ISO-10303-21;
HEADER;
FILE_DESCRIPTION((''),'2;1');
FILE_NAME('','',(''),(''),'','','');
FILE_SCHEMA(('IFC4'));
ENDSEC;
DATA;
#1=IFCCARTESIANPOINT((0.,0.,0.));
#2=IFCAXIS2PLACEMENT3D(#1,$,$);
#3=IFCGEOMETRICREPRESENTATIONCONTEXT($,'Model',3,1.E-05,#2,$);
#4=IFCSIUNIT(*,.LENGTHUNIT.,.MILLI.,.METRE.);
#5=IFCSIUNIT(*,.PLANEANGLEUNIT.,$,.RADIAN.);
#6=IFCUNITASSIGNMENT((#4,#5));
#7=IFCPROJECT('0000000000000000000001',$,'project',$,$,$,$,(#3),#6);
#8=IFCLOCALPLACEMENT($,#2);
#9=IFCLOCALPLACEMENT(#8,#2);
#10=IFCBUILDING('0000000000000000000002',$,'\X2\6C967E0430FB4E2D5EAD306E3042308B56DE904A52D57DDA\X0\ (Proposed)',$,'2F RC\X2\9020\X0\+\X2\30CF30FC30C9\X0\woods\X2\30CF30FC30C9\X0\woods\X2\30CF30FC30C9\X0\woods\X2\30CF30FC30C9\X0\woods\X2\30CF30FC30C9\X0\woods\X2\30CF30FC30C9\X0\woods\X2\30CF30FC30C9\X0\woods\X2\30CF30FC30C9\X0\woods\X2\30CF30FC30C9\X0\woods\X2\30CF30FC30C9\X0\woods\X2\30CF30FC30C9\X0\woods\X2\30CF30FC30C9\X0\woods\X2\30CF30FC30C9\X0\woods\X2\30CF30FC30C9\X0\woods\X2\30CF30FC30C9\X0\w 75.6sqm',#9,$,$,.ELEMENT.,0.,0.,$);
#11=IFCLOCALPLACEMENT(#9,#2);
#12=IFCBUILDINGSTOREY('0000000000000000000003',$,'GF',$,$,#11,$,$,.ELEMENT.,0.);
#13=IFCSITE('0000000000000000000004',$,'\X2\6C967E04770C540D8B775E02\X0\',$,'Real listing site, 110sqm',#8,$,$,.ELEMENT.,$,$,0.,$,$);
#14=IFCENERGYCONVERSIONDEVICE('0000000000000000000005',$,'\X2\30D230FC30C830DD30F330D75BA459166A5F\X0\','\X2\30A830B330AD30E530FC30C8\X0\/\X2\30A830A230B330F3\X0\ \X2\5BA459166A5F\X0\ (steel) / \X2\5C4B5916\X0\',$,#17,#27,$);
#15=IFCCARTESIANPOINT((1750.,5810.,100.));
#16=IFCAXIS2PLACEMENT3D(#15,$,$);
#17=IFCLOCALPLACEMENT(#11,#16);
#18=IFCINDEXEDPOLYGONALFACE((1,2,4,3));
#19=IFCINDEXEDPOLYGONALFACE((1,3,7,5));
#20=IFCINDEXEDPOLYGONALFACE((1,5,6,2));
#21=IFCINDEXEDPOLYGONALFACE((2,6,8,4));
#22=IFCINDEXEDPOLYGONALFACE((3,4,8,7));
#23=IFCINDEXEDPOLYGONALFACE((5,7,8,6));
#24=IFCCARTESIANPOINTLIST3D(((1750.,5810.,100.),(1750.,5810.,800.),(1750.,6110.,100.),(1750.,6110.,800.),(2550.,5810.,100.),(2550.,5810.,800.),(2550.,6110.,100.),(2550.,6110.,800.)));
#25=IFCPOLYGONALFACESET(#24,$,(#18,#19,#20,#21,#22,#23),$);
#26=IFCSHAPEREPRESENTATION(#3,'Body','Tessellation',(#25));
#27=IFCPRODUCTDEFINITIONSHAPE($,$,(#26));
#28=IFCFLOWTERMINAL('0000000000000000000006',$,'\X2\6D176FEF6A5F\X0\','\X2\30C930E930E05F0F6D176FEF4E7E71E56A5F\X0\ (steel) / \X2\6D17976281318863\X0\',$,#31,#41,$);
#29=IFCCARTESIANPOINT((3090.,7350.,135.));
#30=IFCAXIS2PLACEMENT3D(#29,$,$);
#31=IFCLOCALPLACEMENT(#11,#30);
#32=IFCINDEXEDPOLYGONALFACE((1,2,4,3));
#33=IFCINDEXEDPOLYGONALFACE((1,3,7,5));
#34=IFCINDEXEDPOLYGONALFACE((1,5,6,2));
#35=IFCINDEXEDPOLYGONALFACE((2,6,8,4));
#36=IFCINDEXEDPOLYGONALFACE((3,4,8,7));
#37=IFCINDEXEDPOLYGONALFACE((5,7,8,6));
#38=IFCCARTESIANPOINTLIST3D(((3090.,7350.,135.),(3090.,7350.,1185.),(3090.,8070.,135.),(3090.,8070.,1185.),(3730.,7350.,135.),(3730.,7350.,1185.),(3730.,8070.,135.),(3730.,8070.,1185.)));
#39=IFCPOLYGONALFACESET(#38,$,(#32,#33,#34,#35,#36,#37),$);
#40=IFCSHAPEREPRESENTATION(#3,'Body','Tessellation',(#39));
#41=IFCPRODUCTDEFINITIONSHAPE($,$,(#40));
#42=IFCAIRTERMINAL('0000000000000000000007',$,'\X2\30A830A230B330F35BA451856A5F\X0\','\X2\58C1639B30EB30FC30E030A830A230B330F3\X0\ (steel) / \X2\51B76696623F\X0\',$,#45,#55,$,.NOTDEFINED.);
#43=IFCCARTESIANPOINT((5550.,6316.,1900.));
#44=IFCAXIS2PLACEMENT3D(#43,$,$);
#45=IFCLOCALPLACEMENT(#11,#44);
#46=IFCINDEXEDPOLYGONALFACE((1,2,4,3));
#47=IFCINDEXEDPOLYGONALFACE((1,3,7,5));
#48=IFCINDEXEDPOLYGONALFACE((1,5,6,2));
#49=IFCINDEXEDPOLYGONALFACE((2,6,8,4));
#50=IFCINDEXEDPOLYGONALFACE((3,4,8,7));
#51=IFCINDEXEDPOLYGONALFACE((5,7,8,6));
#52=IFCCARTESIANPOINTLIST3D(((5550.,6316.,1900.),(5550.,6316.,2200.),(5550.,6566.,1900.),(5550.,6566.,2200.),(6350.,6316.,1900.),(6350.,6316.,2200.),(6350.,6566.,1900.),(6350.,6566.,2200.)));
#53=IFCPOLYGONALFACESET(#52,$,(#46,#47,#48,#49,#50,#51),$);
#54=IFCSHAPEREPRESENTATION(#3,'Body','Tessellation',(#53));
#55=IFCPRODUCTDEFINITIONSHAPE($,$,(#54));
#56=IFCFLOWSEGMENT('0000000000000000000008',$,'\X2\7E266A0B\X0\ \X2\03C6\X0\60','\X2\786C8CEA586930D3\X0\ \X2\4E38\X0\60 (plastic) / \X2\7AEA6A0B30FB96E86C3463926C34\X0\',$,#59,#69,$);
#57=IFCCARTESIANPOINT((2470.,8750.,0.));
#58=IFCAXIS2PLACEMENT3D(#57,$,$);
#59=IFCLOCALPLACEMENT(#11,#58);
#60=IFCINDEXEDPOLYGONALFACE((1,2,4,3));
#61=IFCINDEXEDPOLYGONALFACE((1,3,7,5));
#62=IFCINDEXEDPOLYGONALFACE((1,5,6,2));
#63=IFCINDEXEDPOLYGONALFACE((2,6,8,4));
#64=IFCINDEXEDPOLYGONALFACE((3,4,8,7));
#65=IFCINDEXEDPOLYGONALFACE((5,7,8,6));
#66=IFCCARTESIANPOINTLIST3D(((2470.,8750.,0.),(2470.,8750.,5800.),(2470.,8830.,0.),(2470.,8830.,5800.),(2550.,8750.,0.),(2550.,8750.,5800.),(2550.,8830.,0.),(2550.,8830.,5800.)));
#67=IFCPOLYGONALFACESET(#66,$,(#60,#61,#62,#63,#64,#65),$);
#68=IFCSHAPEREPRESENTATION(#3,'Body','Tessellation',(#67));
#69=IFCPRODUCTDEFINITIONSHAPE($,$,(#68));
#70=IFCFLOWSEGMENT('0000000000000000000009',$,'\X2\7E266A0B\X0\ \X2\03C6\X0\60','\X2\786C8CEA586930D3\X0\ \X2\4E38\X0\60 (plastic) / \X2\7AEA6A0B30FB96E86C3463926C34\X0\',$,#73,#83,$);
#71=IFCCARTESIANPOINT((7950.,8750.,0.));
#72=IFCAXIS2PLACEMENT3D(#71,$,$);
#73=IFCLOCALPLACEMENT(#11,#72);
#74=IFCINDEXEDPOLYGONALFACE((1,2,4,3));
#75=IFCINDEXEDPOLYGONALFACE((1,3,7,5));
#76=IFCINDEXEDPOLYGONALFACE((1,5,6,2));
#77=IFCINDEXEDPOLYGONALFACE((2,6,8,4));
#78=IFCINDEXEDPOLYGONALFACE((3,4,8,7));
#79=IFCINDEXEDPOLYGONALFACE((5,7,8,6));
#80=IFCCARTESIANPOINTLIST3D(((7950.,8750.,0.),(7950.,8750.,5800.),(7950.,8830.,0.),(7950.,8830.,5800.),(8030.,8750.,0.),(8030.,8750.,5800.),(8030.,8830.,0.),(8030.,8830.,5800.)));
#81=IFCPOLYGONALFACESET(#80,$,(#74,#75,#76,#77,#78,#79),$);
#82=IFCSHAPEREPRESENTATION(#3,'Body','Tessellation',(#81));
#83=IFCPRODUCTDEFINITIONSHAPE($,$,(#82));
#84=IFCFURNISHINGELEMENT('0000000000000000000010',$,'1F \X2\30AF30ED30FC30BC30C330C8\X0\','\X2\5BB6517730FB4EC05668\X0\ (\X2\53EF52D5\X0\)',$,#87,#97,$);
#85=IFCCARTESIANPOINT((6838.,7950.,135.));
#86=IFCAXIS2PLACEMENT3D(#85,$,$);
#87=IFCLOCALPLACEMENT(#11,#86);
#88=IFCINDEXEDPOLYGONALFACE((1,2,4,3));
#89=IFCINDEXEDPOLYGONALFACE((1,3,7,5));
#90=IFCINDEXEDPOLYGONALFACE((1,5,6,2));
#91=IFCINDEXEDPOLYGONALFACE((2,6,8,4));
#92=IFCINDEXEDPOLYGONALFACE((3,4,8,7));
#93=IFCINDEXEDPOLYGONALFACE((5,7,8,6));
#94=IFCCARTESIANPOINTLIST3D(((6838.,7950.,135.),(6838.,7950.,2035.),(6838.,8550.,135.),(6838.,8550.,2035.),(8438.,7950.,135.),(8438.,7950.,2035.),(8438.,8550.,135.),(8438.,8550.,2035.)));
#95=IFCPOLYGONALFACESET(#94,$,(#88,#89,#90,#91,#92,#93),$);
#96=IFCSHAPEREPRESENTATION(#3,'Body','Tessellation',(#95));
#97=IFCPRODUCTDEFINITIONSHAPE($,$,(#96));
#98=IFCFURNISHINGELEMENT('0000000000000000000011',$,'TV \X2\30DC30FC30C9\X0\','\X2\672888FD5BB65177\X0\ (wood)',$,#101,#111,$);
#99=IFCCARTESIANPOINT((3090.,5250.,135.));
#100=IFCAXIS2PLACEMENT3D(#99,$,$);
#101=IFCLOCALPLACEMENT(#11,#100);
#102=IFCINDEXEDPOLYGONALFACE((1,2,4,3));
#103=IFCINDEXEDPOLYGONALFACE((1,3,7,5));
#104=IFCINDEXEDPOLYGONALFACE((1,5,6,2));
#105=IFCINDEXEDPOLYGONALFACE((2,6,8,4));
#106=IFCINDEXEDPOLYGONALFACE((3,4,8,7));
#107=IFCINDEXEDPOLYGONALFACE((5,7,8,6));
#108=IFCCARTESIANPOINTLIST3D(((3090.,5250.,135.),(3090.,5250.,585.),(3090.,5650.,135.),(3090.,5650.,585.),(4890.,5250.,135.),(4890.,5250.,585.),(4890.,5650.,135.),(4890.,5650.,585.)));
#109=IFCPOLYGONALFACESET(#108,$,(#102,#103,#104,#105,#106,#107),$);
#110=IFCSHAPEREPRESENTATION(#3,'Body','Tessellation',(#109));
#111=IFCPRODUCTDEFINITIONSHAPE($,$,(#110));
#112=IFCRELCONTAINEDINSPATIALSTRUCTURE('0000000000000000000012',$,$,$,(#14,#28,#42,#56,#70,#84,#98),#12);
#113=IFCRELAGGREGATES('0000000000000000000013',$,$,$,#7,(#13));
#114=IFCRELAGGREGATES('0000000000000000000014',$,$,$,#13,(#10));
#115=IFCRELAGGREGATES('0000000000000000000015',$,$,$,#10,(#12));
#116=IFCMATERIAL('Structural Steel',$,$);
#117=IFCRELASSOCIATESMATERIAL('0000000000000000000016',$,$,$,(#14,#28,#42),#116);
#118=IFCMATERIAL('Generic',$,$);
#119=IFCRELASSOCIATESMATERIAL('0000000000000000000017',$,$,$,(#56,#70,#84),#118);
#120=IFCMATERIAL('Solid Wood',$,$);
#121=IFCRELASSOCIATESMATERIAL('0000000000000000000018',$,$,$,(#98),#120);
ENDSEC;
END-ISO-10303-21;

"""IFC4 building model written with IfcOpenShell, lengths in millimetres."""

from ifc_helpers import new_model, si_unit, frame, frame_2d, origin, place, context, project, spatial, rectangle, extrude, material, element, save


model = new_model("IFC4")

# Units and contexts
model_context = context("Model", 3, precision=1e-05, world=origin())
ifc_project = project(units=[si_unit("LENGTHUNIT", "METRE", prefix="MILLI"), si_unit("PLANEANGLEUNIT", "RADIAN")], contexts=[model_context])

# Site, building, storey
site_placement = place(None, origin())
site = spatial("IfcSite", under=ifc_project, at=site_placement, Name="沖縄県名護市", ObjectType="Real listing site, 110sqm", CompositionType="ELEMENT", RefElevation=0.0)
building_placement = place(site_placement, origin())
building = spatial("IfcBuilding", under=site, at=building_placement, Name="沖縄・中庭のある回遊動線 (Proposed)", ObjectType="2F RC造+ハードwoodsハードwoodsハードwoodsハードwoodsハードwoodsハードwoodsハードwoodsハードwoodsハードwoodsハードwoodsハードwoodsハードwoodsハードwoodsハードwoodsハードw 75.6sqm", CompositionType="ELEMENT", ElevationOfRefHeight=0.0, ElevationOfTerrain=0.0)
storey_placement = place(building_placement, origin())
storey = spatial("IfcBuildingStorey", under=building, at=storey_placement, Name="GF", CompositionType="ELEMENT", Elevation=0.0)

# Shared definitions
ifc_material_1 = material(Name="Solid Wood")

# Shared definitions
ifc_material_2 = material(Name="Generic")

# Shared definitions
ifc_material_3 = material(Name="Structural Steel")

# Energy conversion device
energy_conversion_device_placement = place(storey_placement, frame((1750.0, 5810.0, 100.0)))
element("IfcEnergyConversionDevice", 1, at=energy_conversion_device_placement, inside=storey, material=ifc_material_3, Name="ヒートポンプ室外機", Description="エコキュート/エアコン 室外機 (steel) / 屋外", context=model_context, shape_type="SweptSolid", body=[
    extrude(rectangle(XDim=800.0, YDim=300.0, at=frame_2d((400.0, 150.0))), frame((1750.0, 5810.0, 100.0)), (0.0, 0.0, 1.0), 700.0),
])

# Flow terminal
flow_terminal_placement = place(storey_placement, frame((3090.0, 7350.0, 135.0)))
element("IfcFlowTerminal", 2, at=flow_terminal_placement, inside=storey, material=ifc_material_3, Name="洗濯機", Description="ドラム式洗濯乾燥機 (steel) / 洗面脱衣", context=model_context, shape_type="SweptSolid", body=[
    extrude(rectangle(XDim=640.0, YDim=720.0, at=frame_2d((320.0, 360.0))), frame((3090.0, 7350.0, 135.0)), (0.0, 0.0, 1.0), 1050.0),
])

# Air terminal
air_terminal_placement = place(storey_placement, frame((5550.0, 6316.0, 1900.0)))
element("IfcAirTerminal", 3, at=air_terminal_placement, inside=storey, material=ifc_material_3, Name="エアコン室内機", Description="壁掛ルームエアコン (steel) / 冷暖房", PredefinedType="NOTDEFINED", context=model_context, shape_type="SweptSolid", body=[
    extrude(rectangle(XDim=800.0, YDim=250.0, at=frame_2d((400.0, 125.0))), frame((5550.0, 6316.0, 1900.0)), (0.0, 0.0, 1.0), 300.0),
])

# Flow segments
flow_segment_1_placement = place(storey_placement, frame((2470.0, 8750.0, 0.0)))
element("IfcFlowSegment", 4, at=flow_segment_1_placement, inside=storey, material=ifc_material_2, Name="縦樋 φ60", Description="硬質塩ビ 丸60 (plastic) / 竪樋・雨水排水", context=model_context, shape_type="SweptSolid", body=[
    extrude(rectangle(XDim=80.0, YDim=80.0, at=frame_2d((40.0, 40.0))), frame((2470.0, 8750.0, 0.0)), (0.0, 0.0, 1.0), 5800.0),
])
flow_segment_2_placement = place(storey_placement, frame((7950.0, 8750.0, 0.0)))
element("IfcFlowSegment", 5, at=flow_segment_2_placement, inside=storey, material=ifc_material_2, Name="縦樋 φ60", Description="硬質塩ビ 丸60 (plastic) / 竪樋・雨水排水", context=model_context, shape_type="SweptSolid", body=[
    extrude(rectangle(XDim=80.0, YDim=80.0, at=frame_2d((40.0, 40.0))), frame((7950.0, 8750.0, 0.0)), (0.0, 0.0, 1.0), 5800.0),
])

# Furnishing elements
furnishing_1_placement = place(storey_placement, frame((6838.0, 7950.0, 135.0)))
element("IfcFurnishingElement", 6, at=furnishing_1_placement, inside=storey, material=ifc_material_2, Name="1F クローゼット", Description="家具・什器 (可動)", context=model_context, shape_type="SweptSolid", body=[
    extrude(rectangle(XDim=1600.0, YDim=600.0, at=frame_2d((800.0, 300.0))), frame((6838.0, 7950.0, 135.0)), (0.0, 0.0, 1.0), 1900.0),
])
furnishing_2_placement = place(storey_placement, frame((3090.0, 5250.0, 135.0)))
element("IfcFurnishingElement", 7, at=furnishing_2_placement, inside=storey, material=ifc_material_1, Name="TV ボード", Description="木製家具 (wood)", context=model_context, shape_type="SweptSolid", body=[
    extrude(rectangle(XDim=1800.0, YDim=400.0, at=frame_2d((900.0, 200.0))), frame((3090.0, 5250.0, 135.0)), (0.0, 0.0, 1.0), 450.0),
])

save(model, "model.ifc")
